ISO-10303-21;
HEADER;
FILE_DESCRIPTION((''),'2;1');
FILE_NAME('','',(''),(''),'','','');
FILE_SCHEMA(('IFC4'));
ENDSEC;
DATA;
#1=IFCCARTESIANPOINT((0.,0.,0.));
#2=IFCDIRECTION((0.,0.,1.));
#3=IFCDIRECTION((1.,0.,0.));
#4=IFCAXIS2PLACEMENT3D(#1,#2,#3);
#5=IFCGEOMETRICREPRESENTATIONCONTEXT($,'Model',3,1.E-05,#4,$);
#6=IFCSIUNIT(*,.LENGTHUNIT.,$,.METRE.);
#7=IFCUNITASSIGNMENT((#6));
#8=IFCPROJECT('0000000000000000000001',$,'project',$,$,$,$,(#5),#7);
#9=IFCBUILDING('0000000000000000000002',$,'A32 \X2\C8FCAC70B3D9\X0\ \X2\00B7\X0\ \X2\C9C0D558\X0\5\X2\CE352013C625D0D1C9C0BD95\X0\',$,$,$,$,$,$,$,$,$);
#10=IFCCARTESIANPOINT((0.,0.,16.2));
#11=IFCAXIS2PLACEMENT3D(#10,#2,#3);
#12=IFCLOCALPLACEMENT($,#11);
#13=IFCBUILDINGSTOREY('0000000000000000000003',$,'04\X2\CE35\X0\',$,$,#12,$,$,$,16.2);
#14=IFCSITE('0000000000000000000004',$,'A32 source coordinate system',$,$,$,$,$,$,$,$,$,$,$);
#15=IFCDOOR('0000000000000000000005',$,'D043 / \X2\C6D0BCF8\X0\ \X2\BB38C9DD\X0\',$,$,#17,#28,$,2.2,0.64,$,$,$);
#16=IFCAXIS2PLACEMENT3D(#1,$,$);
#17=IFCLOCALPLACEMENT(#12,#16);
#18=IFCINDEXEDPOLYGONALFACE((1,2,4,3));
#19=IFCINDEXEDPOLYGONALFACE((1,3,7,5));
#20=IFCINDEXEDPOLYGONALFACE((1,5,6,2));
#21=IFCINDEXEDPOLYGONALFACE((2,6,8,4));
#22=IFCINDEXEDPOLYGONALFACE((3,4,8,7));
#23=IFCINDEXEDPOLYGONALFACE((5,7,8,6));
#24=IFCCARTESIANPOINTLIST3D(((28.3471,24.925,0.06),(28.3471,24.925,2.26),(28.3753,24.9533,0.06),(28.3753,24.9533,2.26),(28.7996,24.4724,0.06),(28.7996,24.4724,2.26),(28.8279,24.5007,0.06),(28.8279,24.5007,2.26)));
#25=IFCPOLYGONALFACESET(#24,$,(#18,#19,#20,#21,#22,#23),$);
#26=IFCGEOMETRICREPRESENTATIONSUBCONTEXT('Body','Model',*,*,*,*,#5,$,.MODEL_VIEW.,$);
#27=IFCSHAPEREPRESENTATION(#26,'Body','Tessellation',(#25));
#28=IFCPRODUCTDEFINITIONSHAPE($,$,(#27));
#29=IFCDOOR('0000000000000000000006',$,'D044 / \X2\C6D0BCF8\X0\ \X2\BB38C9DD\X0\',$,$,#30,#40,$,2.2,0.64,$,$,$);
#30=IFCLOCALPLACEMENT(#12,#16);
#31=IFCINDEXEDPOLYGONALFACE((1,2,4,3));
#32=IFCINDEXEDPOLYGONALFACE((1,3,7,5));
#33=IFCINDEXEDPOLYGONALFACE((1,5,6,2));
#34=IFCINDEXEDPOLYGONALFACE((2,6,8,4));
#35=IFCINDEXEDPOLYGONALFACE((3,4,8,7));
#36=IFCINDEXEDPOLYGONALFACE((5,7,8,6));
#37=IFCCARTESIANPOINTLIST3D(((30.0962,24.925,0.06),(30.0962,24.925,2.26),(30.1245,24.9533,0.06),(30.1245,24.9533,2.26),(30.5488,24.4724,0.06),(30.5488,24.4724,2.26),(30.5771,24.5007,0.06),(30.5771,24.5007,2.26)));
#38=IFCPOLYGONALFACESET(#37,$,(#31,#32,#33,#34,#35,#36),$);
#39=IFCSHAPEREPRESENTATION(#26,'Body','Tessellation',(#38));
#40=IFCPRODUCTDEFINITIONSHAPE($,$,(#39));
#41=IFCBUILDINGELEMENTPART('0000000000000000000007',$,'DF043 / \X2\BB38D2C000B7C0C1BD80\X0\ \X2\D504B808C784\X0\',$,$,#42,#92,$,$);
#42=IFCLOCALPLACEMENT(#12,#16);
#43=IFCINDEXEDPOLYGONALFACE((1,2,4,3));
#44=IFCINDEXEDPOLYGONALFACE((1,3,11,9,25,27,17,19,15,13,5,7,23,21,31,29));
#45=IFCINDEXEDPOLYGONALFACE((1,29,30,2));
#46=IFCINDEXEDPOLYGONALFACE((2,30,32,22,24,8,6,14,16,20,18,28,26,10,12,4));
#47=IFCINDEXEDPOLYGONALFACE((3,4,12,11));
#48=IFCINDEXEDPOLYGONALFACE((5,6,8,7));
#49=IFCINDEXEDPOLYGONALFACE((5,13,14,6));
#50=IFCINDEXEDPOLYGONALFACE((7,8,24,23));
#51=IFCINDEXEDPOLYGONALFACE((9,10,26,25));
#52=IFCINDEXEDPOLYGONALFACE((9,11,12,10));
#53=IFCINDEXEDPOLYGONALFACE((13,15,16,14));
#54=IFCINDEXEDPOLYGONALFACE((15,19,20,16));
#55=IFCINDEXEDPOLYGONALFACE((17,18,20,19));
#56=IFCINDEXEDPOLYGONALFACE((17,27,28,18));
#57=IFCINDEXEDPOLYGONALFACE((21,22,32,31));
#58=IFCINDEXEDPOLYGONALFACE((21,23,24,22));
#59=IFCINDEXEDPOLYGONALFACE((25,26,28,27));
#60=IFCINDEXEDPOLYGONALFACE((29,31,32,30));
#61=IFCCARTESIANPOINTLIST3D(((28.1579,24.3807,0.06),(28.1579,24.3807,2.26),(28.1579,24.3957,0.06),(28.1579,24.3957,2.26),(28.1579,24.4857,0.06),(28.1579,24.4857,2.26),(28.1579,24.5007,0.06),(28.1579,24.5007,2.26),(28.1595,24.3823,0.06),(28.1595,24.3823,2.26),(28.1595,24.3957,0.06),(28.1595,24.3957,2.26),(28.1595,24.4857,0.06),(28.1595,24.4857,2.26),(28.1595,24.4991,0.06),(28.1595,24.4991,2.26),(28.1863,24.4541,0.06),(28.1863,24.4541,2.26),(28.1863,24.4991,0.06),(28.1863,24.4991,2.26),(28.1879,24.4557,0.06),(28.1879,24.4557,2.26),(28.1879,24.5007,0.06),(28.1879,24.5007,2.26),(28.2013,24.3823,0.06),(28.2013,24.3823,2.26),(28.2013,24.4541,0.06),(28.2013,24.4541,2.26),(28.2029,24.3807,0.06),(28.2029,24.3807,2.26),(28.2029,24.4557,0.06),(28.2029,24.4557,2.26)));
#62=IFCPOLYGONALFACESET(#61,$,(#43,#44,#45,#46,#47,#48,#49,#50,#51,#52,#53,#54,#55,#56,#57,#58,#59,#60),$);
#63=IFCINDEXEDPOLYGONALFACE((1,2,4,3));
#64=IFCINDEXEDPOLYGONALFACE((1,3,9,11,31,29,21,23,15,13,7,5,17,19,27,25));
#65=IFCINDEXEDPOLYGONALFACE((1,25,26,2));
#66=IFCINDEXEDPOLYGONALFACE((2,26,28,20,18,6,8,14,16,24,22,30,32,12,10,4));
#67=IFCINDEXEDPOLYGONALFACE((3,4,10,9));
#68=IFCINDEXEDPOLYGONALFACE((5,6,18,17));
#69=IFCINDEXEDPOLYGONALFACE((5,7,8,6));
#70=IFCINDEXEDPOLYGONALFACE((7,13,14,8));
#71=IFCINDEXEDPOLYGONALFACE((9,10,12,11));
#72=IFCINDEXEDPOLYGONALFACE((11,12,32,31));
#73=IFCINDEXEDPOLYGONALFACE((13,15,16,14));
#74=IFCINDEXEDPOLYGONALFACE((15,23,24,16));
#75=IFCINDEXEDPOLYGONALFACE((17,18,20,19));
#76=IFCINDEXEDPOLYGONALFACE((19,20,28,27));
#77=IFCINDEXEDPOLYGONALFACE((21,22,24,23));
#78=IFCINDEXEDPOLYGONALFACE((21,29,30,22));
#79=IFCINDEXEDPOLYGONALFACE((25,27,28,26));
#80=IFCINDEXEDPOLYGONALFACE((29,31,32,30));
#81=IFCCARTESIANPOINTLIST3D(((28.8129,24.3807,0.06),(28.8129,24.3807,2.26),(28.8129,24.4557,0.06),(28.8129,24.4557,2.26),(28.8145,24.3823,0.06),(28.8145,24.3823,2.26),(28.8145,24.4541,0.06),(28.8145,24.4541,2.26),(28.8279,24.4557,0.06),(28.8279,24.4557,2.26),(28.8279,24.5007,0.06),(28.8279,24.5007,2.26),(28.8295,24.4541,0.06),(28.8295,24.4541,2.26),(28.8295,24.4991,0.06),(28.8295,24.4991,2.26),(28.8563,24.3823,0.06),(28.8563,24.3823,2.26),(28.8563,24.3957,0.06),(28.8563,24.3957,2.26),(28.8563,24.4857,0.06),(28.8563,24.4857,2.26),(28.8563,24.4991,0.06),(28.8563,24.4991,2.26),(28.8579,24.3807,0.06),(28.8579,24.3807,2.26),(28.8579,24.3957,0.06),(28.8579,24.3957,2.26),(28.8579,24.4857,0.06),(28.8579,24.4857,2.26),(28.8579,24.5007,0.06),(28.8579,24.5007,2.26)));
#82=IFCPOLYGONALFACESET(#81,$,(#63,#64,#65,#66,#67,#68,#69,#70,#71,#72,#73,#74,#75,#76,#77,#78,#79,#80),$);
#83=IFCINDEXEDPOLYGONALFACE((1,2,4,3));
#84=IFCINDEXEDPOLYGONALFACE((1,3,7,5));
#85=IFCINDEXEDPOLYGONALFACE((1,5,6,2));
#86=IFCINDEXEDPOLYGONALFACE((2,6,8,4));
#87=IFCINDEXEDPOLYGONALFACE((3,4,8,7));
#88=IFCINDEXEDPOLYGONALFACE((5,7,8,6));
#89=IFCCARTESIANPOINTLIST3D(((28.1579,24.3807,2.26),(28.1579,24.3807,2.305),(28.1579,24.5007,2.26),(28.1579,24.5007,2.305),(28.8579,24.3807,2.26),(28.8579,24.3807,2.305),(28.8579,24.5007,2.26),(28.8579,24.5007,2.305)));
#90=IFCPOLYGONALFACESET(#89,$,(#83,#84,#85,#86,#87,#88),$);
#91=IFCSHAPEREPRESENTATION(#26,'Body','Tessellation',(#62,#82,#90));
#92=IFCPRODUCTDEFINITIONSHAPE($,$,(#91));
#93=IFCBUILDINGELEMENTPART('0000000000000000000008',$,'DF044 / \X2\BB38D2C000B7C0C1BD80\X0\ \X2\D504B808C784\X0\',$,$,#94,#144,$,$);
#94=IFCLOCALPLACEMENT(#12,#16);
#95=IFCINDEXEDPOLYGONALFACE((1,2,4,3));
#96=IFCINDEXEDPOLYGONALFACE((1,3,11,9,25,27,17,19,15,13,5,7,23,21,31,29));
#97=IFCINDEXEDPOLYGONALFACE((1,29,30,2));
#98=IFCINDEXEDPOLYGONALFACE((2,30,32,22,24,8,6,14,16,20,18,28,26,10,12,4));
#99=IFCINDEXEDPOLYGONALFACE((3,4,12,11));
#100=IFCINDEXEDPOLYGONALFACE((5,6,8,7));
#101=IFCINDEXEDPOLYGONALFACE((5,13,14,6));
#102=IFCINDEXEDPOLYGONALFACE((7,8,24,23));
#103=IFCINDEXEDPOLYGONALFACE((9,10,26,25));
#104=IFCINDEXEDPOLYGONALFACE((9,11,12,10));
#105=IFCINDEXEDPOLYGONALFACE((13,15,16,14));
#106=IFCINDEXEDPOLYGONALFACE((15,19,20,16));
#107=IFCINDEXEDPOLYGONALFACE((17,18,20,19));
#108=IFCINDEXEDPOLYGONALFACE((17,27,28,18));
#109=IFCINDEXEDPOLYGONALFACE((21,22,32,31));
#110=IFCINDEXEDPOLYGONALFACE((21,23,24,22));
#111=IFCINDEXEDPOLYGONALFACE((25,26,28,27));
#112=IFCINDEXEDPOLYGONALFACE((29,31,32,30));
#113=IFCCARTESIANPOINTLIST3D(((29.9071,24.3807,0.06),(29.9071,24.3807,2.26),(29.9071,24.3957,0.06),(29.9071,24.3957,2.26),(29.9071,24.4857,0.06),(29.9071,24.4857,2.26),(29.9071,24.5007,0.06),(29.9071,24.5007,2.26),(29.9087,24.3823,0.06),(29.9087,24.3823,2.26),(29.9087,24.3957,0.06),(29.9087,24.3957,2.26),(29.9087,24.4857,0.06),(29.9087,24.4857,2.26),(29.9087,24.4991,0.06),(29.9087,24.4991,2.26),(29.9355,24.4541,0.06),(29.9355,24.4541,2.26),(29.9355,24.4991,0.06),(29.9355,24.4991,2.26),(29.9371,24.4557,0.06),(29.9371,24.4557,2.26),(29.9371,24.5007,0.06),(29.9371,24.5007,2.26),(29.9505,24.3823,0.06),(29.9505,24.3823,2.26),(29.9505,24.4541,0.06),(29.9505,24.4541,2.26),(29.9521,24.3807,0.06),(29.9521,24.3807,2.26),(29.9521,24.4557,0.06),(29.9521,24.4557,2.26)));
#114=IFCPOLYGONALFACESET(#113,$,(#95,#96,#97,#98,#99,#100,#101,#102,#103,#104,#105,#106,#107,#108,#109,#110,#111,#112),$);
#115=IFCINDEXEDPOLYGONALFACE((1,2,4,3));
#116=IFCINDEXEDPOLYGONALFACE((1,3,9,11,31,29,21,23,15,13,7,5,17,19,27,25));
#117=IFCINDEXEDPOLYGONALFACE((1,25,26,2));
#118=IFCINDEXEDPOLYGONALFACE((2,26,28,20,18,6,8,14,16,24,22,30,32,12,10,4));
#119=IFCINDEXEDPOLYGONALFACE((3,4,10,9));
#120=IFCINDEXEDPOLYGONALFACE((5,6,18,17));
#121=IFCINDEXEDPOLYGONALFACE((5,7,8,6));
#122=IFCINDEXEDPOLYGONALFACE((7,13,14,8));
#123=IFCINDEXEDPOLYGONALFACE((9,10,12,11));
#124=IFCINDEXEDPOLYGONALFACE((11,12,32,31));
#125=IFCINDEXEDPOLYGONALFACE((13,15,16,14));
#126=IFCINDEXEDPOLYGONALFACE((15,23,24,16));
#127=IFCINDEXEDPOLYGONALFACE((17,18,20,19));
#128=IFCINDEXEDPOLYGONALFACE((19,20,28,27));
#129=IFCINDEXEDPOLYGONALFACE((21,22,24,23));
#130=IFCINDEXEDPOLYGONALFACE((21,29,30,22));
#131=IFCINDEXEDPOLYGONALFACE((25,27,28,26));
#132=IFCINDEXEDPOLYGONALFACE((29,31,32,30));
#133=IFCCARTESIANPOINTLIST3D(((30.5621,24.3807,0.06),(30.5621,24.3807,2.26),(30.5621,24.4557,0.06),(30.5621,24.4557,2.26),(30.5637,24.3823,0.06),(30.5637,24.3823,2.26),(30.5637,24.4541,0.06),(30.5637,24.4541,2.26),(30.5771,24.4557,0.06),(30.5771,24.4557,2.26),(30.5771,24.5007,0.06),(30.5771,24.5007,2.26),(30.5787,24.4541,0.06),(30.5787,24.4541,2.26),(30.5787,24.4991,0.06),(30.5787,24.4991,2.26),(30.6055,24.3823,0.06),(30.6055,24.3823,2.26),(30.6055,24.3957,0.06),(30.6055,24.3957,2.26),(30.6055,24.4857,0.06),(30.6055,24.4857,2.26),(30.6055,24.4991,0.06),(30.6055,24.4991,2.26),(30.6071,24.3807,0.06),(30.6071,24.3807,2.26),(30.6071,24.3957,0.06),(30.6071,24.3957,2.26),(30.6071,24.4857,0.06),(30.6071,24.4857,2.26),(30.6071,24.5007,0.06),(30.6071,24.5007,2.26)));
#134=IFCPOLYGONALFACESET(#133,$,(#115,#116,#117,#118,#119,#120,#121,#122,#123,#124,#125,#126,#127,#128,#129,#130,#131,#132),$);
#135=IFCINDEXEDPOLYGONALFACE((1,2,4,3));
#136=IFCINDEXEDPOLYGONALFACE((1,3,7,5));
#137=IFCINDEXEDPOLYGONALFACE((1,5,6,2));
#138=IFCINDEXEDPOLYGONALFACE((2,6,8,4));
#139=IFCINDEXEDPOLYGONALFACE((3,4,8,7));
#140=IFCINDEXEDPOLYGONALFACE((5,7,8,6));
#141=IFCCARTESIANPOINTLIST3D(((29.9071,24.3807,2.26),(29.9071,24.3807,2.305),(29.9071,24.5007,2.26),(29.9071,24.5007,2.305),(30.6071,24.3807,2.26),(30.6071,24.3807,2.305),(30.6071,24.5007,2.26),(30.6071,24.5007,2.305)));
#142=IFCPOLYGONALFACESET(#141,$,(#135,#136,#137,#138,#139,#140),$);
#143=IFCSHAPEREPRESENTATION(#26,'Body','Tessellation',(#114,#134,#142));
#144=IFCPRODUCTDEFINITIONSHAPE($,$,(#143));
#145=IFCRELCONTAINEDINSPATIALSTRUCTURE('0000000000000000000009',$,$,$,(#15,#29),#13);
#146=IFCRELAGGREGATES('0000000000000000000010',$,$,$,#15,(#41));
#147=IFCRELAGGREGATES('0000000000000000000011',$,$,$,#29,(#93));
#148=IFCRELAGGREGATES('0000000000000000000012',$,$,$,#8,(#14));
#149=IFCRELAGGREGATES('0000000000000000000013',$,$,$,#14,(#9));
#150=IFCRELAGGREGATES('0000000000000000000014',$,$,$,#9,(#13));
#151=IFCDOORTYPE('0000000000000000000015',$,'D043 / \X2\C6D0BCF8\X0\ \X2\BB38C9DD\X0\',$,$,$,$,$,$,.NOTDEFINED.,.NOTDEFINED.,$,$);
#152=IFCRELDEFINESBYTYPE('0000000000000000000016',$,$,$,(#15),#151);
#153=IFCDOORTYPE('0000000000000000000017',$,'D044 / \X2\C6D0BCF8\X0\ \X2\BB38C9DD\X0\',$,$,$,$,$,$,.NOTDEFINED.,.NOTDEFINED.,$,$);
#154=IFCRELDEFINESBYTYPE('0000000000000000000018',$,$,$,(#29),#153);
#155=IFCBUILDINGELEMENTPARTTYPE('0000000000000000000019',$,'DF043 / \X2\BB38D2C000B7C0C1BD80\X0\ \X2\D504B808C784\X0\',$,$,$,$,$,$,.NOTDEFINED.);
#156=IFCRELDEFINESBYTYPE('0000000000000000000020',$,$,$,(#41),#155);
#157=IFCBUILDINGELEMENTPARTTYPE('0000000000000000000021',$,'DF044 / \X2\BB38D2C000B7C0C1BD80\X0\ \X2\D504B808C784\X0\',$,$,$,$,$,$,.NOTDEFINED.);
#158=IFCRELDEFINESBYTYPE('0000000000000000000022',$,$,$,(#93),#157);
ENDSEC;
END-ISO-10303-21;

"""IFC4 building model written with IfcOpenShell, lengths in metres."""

from ifc_helpers import new_model, si_unit, frame, origin, origin_with_axes, place, context, subcontext, project, spatial, polyline, outline, extrude, source, transform, mapped, type_object, type_shapes, element, aggregate, save


model = new_model("IFC4")

# Units and contexts
model_context = context("Model", 3, precision=1e-05, world=origin_with_axes())
body_context = subcontext(model_context, "Body", "Model", "MODEL_VIEW")
ifc_project = project(units=[si_unit("LENGTHUNIT", "METRE")], contexts=[model_context])

# Site, building, storey
storey_placement = place(None, frame((0.0, 0.0, 16.2), z_axis=(0.0, 0.0, 1.0), x_axis=(1.0, 0.0, 0.0)))
site = spatial("IfcSite", under=ifc_project, Name="A32 source coordinate system")
building = spatial("IfcBuilding", under=site, Name="A32 주거동 · 지하5층–옥탑지붕")
storey = spatial("IfcBuildingStorey", under=building, at=storey_placement, Name="04층", Elevation=16.2)

# Doors
door_type_1 = type_object("IfcDoorType", Name="D043 / 원본 문짝", OperationType="NOTDEFINED", PredefinedType="NOTDEFINED")
shared_shape_1 = source(origin(), body_context, "Body", "SweptSolid", [
    extrude(outline(polyline([(28.8279, 24.5007), (28.7996, 24.4724), (28.3471, 24.925), (28.3753, 24.9533), (28.8279, 24.5007)])), frame((0.0, 0.0, 0.06)), (0.0, 0.0, 1.0), 2.2),
])
type_shapes(door_type_1, [shared_shape_1])
door_1_placement = place(storey_placement, origin_with_axes())
door_1 = element("IfcDoor", 1, at=door_1_placement, inside=storey, type_object=door_type_1, Name="D043 / 원본 문짝", OverallHeight=2.2, OverallWidth=0.64, context=body_context, shape_type="MappedRepresentation", body=[
    mapped(shared_shape_1, transform((0.0, 0.0, 0.0), scale=1.0)),
])
door_type_2 = type_object("IfcDoorType", Name="D044 / 원본 문짝", OperationType="NOTDEFINED", PredefinedType="NOTDEFINED")
shared_shape_2 = source(origin(), body_context, "Body", "SweptSolid", [
    extrude(outline(polyline([(30.5771, 24.5007), (30.5488, 24.4724), (30.0962, 24.925), (30.1245, 24.9533), (30.5771, 24.5007)])), frame((0.0, 0.0, 0.06)), (0.0, 0.0, 1.0), 2.2),
])
type_shapes(door_type_2, [shared_shape_2])
door_2_placement = place(storey_placement, origin_with_axes())
door_2 = element("IfcDoor", 2, at=door_2_placement, inside=storey, type_object=door_type_2, Name="D044 / 원본 문짝", OverallHeight=2.2, OverallWidth=0.64, context=body_context, shape_type="MappedRepresentation", body=[
    mapped(shared_shape_2, transform((0.0, 0.0, 0.0), scale=1.0)),
])

# Building element parts
building_element_part_type_1 = type_object("IfcBuildingElementPartType", Name="DF043 / 문틀·상부 프레임", PredefinedType="NOTDEFINED")
shared_shape_3 = source(origin(), body_context, "Body", "SweptSolid", [
    extrude(outline(polyline([(28.1579, 24.4857), (28.1579, 24.5007), (28.1879, 24.5007), (28.1879, 24.4557), (28.2029, 24.4557), (28.2029, 24.3807), (28.1579, 24.3807), (28.1579, 24.3957), (28.1595, 24.3957), (28.1595, 24.3823), (28.2013, 24.3823), (28.2013, 24.4541), (28.1863, 24.4541), (28.1863, 24.4991), (28.1595, 24.4991), (28.1595, 24.4857), (28.1579, 24.4857)])), frame((0.0, 0.0, 0.06)), (0.0, 0.0, 1.0), 2.2),
    extrude(outline(polyline([(28.8563, 24.4991), (28.8295, 24.4991), (28.8295, 24.4541), (28.8145, 24.4541), (28.8145, 24.3823), (28.8563, 24.3823), (28.8563, 24.3957), (28.8579, 24.3957), (28.8579, 24.3807), (28.8129, 24.3807), (28.8129, 24.4557), (28.8279, 24.4557), (28.8279, 24.5007), (28.8579, 24.5007), (28.8579, 24.4857), (28.8563, 24.4857), (28.8563, 24.4991)])), frame((0.0, 0.0, 0.06)), (0.0, 0.0, 1.0), 2.2),
    extrude(outline(polyline([(28.1579, 24.3807), (28.1579, 24.5007), (28.8579, 24.5007), (28.8579, 24.3807), (28.1579, 24.3807)])), frame((0.0, 0.0, 2.26)), (0.0, 0.0, 1.0), 0.045),
])
type_shapes(building_element_part_type_1, [shared_shape_3])
building_element_part_1_placement = place(door_1_placement, origin_with_axes())
building_element_part_1 = element("IfcBuildingElementPart", 3, at=building_element_part_1_placement, type_object=building_element_part_type_1, Name="DF043 / 문틀·상부 프레임", context=body_context, shape_type="MappedRepresentation", body=[
    mapped(shared_shape_3, transform((0.0, 0.0, 0.0), scale=1.0)),
])
aggregate(door_1, [building_element_part_1])
building_element_part_type_2 = type_object("IfcBuildingElementPartType", Name="DF044 / 문틀·상부 프레임", PredefinedType="NOTDEFINED")
shared_shape_4 = source(origin(), body_context, "Body", "SweptSolid", [
    extrude(outline(polyline([(29.9071, 24.4857), (29.9071, 24.5007), (29.9371, 24.5007), (29.9371, 24.4557), (29.9521, 24.4557), (29.9521, 24.3807), (29.9071, 24.3807), (29.9071, 24.3957), (29.9087, 24.3957), (29.9087, 24.3823), (29.9505, 24.3823), (29.9505, 24.4541), (29.9355, 24.4541), (29.9355, 24.4991), (29.9087, 24.4991), (29.9087, 24.4857), (29.9071, 24.4857)])), frame((0.0, 0.0, 0.06)), (0.0, 0.0, 1.0), 2.2),
    extrude(outline(polyline([(30.6055, 24.4991), (30.5787, 24.4991), (30.5787, 24.4541), (30.5637, 24.4541), (30.5637, 24.3823), (30.6055, 24.3823), (30.6055, 24.3957), (30.6071, 24.3957), (30.6071, 24.3807), (30.5621, 24.3807), (30.5621, 24.4557), (30.5771, 24.4557), (30.5771, 24.5007), (30.6071, 24.5007), (30.6071, 24.4857), (30.6055, 24.4857), (30.6055, 24.4991)])), frame((0.0, 0.0, 0.06)), (0.0, 0.0, 1.0), 2.2),
    extrude(outline(polyline([(29.9071, 24.3807), (29.9071, 24.5007), (30.6071, 24.5007), (30.6071, 24.3807), (29.9071, 24.3807)])), frame((0.0, 0.0, 2.26)), (0.0, 0.0, 1.0), 0.045),
])
type_shapes(building_element_part_type_2, [shared_shape_4])
building_element_part_2_placement = place(door_2_placement, origin_with_axes())
building_element_part_2 = element("IfcBuildingElementPart", 4, at=building_element_part_2_placement, type_object=building_element_part_type_2, Name="DF044 / 문틀·상부 프레임", context=body_context, shape_type="MappedRepresentation", body=[
    mapped(shared_shape_4, transform((0.0, 0.0, 0.0), scale=1.0)),
])
aggregate(door_2, [building_element_part_2])

save(model, "model.ifc")
